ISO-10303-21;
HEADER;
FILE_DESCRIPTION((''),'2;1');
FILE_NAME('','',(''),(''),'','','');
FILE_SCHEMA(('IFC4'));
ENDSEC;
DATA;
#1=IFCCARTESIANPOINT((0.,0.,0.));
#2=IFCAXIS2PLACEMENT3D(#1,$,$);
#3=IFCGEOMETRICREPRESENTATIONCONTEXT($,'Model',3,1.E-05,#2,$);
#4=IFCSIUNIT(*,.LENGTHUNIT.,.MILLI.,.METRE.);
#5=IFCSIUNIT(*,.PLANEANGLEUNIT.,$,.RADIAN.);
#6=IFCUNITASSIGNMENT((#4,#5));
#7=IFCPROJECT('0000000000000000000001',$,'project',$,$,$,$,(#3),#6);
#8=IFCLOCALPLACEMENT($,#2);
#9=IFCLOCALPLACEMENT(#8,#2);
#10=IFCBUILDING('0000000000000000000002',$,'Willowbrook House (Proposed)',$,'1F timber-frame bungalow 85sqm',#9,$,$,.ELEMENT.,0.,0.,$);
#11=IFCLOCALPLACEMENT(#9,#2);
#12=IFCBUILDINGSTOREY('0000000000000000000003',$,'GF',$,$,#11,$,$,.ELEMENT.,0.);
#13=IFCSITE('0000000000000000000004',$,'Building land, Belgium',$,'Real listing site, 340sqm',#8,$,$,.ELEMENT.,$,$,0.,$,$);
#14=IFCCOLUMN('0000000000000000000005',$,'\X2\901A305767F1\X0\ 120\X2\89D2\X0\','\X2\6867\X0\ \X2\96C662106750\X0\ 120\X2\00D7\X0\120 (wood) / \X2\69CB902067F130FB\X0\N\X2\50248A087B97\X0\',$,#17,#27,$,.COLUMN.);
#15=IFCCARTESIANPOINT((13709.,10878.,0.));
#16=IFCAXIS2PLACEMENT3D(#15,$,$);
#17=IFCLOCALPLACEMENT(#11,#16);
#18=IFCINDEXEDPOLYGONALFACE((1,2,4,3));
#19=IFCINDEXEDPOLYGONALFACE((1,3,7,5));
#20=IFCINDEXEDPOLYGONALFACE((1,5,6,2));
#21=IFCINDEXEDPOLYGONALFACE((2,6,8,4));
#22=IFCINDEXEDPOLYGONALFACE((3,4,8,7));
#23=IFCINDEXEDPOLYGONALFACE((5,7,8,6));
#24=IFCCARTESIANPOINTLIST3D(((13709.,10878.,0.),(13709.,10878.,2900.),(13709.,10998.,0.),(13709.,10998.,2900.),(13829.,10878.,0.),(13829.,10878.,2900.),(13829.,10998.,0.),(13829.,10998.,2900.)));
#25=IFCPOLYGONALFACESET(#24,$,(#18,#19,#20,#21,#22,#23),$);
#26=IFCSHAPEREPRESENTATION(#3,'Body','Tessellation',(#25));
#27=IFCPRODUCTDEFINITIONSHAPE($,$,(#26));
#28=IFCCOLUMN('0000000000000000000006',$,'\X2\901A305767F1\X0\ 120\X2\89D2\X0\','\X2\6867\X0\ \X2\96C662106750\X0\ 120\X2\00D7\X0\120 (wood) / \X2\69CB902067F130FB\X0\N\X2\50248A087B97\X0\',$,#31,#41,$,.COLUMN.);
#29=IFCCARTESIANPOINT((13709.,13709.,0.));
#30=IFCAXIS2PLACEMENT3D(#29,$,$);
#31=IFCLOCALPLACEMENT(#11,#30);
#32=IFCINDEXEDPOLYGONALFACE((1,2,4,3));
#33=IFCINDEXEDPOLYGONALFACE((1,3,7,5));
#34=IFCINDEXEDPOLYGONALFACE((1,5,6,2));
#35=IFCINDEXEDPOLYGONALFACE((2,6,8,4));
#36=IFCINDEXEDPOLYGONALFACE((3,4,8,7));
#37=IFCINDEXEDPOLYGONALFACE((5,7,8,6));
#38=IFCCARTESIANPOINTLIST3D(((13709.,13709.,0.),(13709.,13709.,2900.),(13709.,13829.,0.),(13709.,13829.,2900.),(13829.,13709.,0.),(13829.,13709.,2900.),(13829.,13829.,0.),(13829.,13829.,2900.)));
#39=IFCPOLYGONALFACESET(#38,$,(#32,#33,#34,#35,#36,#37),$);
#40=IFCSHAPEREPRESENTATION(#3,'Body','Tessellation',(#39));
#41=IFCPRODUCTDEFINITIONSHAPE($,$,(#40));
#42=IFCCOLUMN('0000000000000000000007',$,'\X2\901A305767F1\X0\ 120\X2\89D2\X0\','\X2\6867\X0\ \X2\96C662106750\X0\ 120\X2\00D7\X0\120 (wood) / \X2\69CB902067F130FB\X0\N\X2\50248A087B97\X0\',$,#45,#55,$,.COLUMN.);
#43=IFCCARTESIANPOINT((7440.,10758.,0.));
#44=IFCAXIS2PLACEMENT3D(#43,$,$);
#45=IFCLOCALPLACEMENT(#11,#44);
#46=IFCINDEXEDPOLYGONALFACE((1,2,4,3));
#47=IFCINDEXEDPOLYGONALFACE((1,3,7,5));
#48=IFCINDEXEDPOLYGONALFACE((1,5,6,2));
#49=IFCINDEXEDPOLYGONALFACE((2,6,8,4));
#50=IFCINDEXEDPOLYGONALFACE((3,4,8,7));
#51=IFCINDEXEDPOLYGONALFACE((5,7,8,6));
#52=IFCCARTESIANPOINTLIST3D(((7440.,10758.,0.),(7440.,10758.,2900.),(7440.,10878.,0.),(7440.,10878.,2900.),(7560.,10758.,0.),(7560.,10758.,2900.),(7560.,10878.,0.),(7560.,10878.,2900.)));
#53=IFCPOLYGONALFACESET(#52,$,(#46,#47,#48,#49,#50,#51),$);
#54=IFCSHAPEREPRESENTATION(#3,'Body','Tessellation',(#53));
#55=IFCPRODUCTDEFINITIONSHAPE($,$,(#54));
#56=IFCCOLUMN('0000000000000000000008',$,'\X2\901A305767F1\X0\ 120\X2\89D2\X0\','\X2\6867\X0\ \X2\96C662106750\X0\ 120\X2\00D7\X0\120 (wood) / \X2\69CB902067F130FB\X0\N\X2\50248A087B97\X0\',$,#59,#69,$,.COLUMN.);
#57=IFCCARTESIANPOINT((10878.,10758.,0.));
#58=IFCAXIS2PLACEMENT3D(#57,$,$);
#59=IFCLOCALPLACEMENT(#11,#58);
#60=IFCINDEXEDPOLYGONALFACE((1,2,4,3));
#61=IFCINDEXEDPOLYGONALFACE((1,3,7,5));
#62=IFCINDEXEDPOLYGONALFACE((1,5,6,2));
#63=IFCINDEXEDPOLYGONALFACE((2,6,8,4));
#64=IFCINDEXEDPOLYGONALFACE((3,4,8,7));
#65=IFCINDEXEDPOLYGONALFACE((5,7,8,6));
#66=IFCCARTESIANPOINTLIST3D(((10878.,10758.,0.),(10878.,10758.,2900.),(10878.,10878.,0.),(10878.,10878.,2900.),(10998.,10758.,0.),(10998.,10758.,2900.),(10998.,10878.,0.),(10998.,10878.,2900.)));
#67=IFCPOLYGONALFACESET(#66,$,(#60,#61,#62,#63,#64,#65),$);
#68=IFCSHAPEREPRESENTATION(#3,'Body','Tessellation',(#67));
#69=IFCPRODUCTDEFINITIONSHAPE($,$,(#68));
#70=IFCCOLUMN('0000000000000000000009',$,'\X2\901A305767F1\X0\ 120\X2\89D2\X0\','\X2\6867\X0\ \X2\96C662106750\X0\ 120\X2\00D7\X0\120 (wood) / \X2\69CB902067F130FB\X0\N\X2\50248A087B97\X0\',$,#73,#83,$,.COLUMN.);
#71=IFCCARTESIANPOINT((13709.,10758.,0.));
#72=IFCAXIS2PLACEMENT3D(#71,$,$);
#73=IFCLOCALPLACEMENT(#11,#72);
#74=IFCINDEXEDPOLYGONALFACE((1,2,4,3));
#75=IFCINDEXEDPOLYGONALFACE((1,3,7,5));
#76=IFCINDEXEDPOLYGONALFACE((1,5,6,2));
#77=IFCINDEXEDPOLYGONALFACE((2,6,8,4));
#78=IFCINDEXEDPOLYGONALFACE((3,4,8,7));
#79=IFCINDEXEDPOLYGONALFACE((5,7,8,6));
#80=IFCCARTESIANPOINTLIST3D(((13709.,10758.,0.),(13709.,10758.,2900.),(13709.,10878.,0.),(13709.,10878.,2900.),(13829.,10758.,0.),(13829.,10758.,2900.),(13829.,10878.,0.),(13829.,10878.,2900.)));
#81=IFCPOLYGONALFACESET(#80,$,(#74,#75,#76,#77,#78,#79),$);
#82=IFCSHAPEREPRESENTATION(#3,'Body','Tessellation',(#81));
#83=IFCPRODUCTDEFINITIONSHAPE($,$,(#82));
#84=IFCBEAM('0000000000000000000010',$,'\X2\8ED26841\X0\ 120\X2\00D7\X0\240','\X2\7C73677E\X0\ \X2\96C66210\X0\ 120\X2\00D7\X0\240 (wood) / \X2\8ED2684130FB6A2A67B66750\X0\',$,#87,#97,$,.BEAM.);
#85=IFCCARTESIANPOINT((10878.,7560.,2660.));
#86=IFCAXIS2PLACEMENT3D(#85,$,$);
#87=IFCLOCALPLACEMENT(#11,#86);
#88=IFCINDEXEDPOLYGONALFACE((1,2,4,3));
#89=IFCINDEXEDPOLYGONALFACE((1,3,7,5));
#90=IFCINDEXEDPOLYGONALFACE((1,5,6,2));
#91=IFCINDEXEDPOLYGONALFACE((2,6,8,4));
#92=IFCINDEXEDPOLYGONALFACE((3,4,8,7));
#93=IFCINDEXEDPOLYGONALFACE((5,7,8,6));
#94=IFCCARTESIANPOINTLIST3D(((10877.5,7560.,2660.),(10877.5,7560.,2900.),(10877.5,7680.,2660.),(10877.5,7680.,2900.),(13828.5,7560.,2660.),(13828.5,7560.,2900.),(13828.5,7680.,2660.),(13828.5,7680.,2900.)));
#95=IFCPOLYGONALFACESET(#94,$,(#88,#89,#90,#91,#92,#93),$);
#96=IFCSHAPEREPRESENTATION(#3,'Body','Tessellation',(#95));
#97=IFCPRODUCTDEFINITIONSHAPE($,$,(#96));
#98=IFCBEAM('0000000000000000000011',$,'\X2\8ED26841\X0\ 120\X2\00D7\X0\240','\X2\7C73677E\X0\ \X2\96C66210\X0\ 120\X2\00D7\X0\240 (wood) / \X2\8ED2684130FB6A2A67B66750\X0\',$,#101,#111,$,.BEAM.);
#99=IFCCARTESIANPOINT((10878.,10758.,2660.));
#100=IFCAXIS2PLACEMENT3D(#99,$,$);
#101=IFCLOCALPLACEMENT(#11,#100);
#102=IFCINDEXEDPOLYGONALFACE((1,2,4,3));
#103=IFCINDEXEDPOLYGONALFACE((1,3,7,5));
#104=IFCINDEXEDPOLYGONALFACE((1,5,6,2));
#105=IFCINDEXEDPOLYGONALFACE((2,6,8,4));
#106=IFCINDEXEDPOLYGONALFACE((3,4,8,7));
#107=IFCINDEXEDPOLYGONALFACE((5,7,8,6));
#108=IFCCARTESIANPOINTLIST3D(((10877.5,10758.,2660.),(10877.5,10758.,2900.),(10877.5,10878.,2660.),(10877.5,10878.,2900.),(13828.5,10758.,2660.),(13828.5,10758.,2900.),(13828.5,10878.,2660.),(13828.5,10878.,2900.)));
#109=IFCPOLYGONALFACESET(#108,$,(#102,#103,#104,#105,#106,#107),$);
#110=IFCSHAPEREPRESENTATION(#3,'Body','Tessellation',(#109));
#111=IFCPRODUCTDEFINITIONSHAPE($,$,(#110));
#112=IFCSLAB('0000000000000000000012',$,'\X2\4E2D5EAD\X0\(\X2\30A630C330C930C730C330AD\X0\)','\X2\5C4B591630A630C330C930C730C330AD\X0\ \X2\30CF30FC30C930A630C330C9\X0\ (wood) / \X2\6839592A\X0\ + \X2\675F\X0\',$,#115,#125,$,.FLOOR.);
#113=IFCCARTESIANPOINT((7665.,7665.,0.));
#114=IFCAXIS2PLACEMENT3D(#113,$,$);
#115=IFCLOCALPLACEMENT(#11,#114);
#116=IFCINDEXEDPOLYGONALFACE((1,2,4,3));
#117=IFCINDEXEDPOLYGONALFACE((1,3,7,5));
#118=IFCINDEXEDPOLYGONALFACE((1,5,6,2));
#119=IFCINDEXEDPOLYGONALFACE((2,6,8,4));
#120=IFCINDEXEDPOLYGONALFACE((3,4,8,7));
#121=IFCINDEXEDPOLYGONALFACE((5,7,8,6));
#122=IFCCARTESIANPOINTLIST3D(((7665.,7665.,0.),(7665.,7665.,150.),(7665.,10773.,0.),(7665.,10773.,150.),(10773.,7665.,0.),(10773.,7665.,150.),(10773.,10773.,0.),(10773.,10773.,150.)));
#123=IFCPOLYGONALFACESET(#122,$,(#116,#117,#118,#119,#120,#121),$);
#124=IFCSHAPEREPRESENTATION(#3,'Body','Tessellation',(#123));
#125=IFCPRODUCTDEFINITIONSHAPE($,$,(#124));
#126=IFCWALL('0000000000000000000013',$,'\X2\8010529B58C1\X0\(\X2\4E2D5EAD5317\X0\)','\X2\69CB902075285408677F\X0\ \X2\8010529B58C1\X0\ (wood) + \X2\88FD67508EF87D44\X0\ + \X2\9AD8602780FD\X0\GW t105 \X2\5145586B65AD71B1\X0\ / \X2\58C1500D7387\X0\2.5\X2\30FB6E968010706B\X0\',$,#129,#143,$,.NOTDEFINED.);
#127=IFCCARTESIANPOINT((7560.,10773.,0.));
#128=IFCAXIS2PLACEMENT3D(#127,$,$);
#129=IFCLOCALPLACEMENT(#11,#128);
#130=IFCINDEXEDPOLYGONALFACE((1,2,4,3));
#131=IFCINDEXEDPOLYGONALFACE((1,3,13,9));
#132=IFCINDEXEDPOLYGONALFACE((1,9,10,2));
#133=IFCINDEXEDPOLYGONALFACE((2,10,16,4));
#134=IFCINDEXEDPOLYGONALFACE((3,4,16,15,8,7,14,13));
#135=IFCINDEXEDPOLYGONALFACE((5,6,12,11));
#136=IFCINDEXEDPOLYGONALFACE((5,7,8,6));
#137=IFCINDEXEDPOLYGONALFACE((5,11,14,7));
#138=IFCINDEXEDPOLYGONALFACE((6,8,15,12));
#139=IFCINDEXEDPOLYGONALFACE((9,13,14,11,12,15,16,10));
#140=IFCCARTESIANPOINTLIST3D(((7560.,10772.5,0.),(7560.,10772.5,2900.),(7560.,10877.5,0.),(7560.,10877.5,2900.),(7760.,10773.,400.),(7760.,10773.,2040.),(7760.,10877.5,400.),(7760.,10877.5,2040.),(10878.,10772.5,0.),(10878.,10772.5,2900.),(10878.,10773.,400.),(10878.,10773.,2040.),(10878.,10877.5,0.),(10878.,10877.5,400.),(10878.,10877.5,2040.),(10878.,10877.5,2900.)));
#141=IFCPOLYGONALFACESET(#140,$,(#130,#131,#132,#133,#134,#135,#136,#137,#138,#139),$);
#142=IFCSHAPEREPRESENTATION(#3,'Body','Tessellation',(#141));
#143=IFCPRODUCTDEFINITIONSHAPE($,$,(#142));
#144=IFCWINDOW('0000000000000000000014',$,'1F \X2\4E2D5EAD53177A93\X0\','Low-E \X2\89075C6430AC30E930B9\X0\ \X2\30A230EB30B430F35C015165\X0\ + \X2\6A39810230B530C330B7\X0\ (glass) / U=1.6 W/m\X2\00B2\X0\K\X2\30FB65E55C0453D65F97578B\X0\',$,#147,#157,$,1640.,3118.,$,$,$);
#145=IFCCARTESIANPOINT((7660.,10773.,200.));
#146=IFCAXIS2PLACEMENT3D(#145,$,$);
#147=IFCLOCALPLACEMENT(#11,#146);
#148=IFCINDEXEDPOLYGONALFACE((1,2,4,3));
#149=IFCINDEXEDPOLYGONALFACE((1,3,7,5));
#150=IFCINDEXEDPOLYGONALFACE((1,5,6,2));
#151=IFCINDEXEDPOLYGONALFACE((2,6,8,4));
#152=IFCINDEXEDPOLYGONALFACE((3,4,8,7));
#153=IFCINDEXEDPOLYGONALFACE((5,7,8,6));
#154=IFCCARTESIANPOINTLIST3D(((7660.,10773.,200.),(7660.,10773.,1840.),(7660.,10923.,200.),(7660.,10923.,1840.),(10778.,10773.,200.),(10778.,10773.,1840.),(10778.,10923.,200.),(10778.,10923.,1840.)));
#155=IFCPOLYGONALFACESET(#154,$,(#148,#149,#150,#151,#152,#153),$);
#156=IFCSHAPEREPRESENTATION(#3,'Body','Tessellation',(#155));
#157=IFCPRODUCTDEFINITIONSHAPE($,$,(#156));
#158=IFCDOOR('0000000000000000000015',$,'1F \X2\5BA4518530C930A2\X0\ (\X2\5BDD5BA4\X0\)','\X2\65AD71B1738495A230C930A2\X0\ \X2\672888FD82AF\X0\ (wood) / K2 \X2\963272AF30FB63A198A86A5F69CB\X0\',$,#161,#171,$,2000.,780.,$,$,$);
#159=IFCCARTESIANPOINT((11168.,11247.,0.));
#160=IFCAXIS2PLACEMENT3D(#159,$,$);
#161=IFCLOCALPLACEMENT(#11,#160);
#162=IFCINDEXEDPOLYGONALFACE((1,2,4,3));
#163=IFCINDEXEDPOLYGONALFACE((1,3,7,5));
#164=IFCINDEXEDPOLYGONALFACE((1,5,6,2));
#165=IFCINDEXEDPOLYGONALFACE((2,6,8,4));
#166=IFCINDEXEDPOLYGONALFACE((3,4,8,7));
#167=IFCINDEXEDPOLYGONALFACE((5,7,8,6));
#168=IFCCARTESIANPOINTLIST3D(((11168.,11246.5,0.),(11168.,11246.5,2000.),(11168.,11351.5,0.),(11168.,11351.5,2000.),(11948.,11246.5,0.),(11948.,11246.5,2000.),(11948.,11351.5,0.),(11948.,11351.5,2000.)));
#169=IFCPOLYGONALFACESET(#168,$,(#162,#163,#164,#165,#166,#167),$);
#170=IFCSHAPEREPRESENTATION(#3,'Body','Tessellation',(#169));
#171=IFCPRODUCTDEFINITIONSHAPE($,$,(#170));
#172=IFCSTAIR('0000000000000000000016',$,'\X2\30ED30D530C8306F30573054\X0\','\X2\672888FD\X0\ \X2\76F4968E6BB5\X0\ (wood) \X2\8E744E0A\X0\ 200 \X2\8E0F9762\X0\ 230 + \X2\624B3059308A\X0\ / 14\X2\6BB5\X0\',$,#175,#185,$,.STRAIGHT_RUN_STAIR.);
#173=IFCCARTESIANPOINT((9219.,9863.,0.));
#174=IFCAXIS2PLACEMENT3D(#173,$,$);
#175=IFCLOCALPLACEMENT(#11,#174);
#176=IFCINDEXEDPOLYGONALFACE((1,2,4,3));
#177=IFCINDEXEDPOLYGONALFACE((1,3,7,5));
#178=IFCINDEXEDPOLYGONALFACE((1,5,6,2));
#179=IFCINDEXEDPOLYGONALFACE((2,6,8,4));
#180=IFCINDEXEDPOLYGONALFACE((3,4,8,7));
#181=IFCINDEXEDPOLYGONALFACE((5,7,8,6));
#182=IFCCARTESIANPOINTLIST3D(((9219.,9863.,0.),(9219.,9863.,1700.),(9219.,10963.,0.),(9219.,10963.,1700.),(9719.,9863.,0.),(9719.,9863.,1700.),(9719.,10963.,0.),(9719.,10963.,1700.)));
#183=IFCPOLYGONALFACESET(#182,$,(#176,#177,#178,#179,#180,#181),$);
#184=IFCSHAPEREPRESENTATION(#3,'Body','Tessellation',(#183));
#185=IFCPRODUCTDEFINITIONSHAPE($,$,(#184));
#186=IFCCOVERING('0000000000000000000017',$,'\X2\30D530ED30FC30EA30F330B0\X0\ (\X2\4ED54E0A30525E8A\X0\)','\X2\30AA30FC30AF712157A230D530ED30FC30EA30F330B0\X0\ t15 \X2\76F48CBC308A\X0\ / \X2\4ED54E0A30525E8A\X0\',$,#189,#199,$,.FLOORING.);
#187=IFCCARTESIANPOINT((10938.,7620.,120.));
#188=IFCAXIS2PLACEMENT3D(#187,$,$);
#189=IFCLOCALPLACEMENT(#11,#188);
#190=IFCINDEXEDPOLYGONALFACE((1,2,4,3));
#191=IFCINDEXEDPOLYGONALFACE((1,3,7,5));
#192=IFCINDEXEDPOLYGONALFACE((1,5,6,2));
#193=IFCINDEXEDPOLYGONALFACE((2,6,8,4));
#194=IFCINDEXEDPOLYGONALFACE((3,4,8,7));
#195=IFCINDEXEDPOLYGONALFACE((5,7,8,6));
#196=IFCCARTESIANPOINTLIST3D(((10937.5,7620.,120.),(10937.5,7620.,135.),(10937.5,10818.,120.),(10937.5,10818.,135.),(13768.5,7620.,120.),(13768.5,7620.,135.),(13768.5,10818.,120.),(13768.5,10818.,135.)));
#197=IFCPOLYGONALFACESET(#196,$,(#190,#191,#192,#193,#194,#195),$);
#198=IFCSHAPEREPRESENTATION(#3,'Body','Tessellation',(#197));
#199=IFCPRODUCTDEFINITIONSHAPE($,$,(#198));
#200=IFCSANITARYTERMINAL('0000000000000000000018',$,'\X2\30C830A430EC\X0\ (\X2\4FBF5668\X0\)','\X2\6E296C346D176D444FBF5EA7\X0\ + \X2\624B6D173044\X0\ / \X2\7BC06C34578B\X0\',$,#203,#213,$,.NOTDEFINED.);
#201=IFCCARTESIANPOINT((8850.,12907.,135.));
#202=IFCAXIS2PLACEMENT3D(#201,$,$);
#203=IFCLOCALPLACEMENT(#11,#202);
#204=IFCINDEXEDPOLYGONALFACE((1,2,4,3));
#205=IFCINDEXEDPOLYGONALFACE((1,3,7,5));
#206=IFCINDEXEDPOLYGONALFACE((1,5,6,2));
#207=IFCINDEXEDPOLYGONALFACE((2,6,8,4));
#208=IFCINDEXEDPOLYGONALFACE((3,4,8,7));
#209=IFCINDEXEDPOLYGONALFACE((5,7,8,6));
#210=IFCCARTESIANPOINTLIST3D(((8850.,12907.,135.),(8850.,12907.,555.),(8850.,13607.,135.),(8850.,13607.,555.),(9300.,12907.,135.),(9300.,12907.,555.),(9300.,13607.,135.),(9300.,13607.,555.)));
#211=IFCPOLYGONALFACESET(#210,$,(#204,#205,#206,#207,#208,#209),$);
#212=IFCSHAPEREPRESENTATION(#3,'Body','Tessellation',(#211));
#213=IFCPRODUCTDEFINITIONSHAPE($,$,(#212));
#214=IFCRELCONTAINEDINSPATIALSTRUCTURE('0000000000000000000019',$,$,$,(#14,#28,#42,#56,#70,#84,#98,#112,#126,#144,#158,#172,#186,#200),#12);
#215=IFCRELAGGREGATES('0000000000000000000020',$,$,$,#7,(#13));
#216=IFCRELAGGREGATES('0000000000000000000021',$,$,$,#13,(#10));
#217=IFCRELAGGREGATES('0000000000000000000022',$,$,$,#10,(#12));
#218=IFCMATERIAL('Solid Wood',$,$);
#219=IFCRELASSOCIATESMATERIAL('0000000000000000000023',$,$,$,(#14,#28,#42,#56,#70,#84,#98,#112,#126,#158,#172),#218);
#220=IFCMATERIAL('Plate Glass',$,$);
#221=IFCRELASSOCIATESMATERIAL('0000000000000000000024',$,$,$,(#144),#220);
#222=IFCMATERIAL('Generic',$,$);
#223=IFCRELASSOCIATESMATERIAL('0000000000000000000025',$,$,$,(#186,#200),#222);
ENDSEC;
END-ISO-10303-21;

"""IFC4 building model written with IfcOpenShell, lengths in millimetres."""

from ifc_helpers import new_model, si_unit, frame, frame_2d, origin, place, context, project, spatial, rectangle, extrude, material, element, fill, save


model = new_model("IFC4")

# Units and contexts
model_context = context("Model", 3, precision=1e-05, world=origin())
ifc_project = project(units=[si_unit("LENGTHUNIT", "METRE", prefix="MILLI"), si_unit("PLANEANGLEUNIT", "RADIAN")], contexts=[model_context])

# Site, building, storey
site_placement = place(None, origin())
site = spatial("IfcSite", under=ifc_project, at=site_placement, Name="Building land, Belgium", ObjectType="Real listing site, 340sqm", CompositionType="ELEMENT", RefElevation=0.0)
building_placement = place(site_placement, origin())
building = spatial("IfcBuilding", under=site, at=building_placement, Name="Willowbrook House (Proposed)", ObjectType="1F timber-frame bungalow 85sqm", CompositionType="ELEMENT", ElevationOfRefHeight=0.0, ElevationOfTerrain=0.0)
storey_placement = place(building_placement, origin())
storey = spatial("IfcBuildingStorey", under=building, at=storey_placement, Name="GF", CompositionType="ELEMENT", Elevation=0.0)

# Columns
ifc_material_1 = material(Name="Solid Wood")
column_1_placement = place(storey_placement, frame((13709.0, 10878.0, 0.0)))
element("IfcColumn", 1, at=column_1_placement, inside=storey, material=ifc_material_1, Name="通し柱 120角", Description="桧 集成材 120×120 (wood) / 構造柱・N値計算", PredefinedType="COLUMN", context=model_context, shape_type="SweptSolid", body=[
    extrude(rectangle(XDim=120.0, YDim=120.0, at=frame_2d((60.0, 60.0))), frame((13709.0, 10878.0, 0.0)), (0.0, 0.0, 1.0), 2900.0),
])
column_2_placement = place(storey_placement, frame((13709.0, 13709.0, 0.0)))
element("IfcColumn", 2, at=column_2_placement, inside=storey, material=ifc_material_1, Name="通し柱 120角", Description="桧 集成材 120×120 (wood) / 構造柱・N値計算", PredefinedType="COLUMN", context=model_context, shape_type="SweptSolid", body=[
    extrude(rectangle(XDim=120.0, YDim=120.0, at=frame_2d((60.0, 60.0))), frame((13709.0, 13709.0, 0.0)), (0.0, 0.0, 1.0), 2900.0),
])
column_3_placement = place(storey_placement, frame((7440.0, 10758.0, 0.0)))
element("IfcColumn", 3, at=column_3_placement, inside=storey, material=ifc_material_1, Name="通し柱 120角", Description="桧 集成材 120×120 (wood) / 構造柱・N値計算", PredefinedType="COLUMN", context=model_context, shape_type="SweptSolid", body=[
    extrude(rectangle(XDim=120.0, YDim=120.0, at=frame_2d((60.0, 60.0))), frame((7440.0, 10758.0, 0.0)), (0.0, 0.0, 1.0), 2900.0),
])
column_4_placement = place(storey_placement, frame((10878.0, 10758.0, 0.0)))
element("IfcColumn", 4, at=column_4_placement, inside=storey, material=ifc_material_1, Name="通し柱 120角", Description="桧 集成材 120×120 (wood) / 構造柱・N値計算", PredefinedType="COLUMN", context=model_context, shape_type="SweptSolid", body=[
    extrude(rectangle(XDim=120.0, YDim=120.0, at=frame_2d((60.0, 60.0))), frame((10878.0, 10758.0, 0.0)), (0.0, 0.0, 1.0), 2900.0),
])
column_5_placement = place(storey_placement, frame((13709.0, 10758.0, 0.0)))
element("IfcColumn", 5, at=column_5_placement, inside=storey, material=ifc_material_1, Name="通し柱 120角", Description="桧 集成材 120×120 (wood) / 構造柱・N値計算", PredefinedType="COLUMN", context=model_context, shape_type="SweptSolid", body=[
    extrude(rectangle(XDim=120.0, YDim=120.0, at=frame_2d((60.0, 60.0))), frame((13709.0, 10758.0, 0.0)), (0.0, 0.0, 1.0), 2900.0),
])

# Beams
beam_1_placement = place(storey_placement, frame((10878.0, 7560.0, 2660.0)))
element("IfcBeam", 6, at=beam_1_placement, inside=storey, material=ifc_material_1, Name="軒桁 120×240", Description="米松 集成 120×240 (wood) / 軒桁・横架材", PredefinedType="BEAM", context=model_context, shape_type="SweptSolid", body=[
    extrude(rectangle(XDim=2951.0, YDim=120.0, at=frame_2d((1475.0, 60.0))), frame((10878.0, 7560.0, 2660.0)), (0.0, 0.0, 1.0), 240.0),
])
beam_2_placement = place(storey_placement, frame((10878.0, 10758.0, 2660.0)))
element("IfcBeam", 7, at=beam_2_placement, inside=storey, material=ifc_material_1, Name="軒桁 120×240", Description="米松 集成 120×240 (wood) / 軒桁・横架材", PredefinedType="BEAM", context=model_context, shape_type="SweptSolid", body=[
    extrude(rectangle(XDim=2951.0, YDim=120.0, at=frame_2d((1475.0, 60.0))), frame((10878.0, 10758.0, 2660.0)), (0.0, 0.0, 1.0), 240.0),
])

# Slab
slab_placement = place(storey_placement, frame((7665.0, 7665.0, 0.0)))
element("IfcSlab", 8, at=slab_placement, inside=storey, material=ifc_material_1, Name="中庭(ウッドデッキ)", Description="屋外ウッドデッキ ハードウッド (wood) / 根太 + 束", PredefinedType="FLOOR", context=model_context, shape_type="SweptSolid", body=[
    extrude(rectangle(XDim=3108.0, YDim=3108.0, at=frame_2d((1554.0, 1554.0))), frame((7665.0, 7665.0, 0.0)), (0.0, 0.0, 1.0), 150.0),
])

# Wall, opening, window
wall_1_placement = place(storey_placement, frame((7560.0, 10773.0, 0.0)))
wall_1 = element("IfcWall", 9, at=wall_1_placement, inside=storey, material=ifc_material_1, Name="耐力壁(中庭北)", Description="構造用合板 耐力壁 (wood) + 製材軸組 + 高性能GW t105 充填断熱 / 壁倍率2.5・準耐火", PredefinedType="NOTDEFINED", context=model_context, shape_type="SweptSolid", body=[
    extrude(rectangle(XDim=3318.0, YDim=105.0, at=frame_2d((1659.0, 52.0))), frame((7560.0, 10773.0, 0.0)), (0.0, 0.0, 1.0), 2900.0),
])
opening_placement = place(storey_placement, frame((7660.0, 10773.0, 200.0)))
opening = element("IfcOpeningElement", 10, at=opening_placement, cuts=wall_1, PredefinedType="NOTDEFINED", context=model_context, shape_type="SweptSolid", body=[
    extrude(rectangle(XDim=3118.0, YDim=150.0, at=frame_2d((1559.0, 75.0))), frame((7660.0, 10773.0, 200.0)), (0.0, 0.0, 1.0), 1640.0),
])
ifc_material_2 = material(Name="Plate Glass")
window_placement = place(storey_placement, frame((7660.0, 10773.0, 200.0)))
window = element("IfcWindow", 11, at=window_placement, inside=storey, material=ifc_material_2, Name="1F 中庭北窓", Description="Low-E 複層ガラス アルゴン封入 + 樹脂サッシ (glass) / U=1.6 W/m²K・日射取得型", OverallHeight=1640.0, OverallWidth=3118.0, context=model_context, shape_type="SweptSolid", body=[
    extrude(rectangle(XDim=3118.0, YDim=150.0, at=frame_2d((1559.0, 75.0))), frame((7660.0, 10773.0, 200.0)), (0.0, 0.0, 1.0), 1640.0),
])
fill(opening, window)

# Door
door_placement = place(storey_placement, frame((11168.0, 11247.0, 0.0)))
element("IfcDoor", 12, at=door_placement, inside=storey, material=ifc_material_1, Name="1F 室内ドア (寝室)", Description="断熱玄関ドア 木製芯 (wood) / K2 防犯・採風機構", OverallHeight=2000.0, OverallWidth=780.0, context=model_context, shape_type="SweptSolid", body=[
    extrude(rectangle(XDim=780.0, YDim=105.0, at=frame_2d((390.0, 52.0))), frame((11168.0, 11247.0, 0.0)), (0.0, 0.0, 1.0), 2000.0),
])

# Stair
stair_placement = place(storey_placement, frame((9219.0, 9863.0, 0.0)))
element("IfcStair", 13, at=stair_placement, inside=storey, material=ifc_material_1, Name="ロフトはしご", Description="木製 直階段 (wood) 蹴上 200 踏面 230 + 手すり / 14段", PredefinedType="STRAIGHT_RUN_STAIR", context=model_context, shape_type="SweptSolid", body=[
    extrude(rectangle(XDim=500.0, YDim=1100.0, at=frame_2d((250.0, 550.0))), frame((9219.0, 9863.0, 0.0)), (0.0, 0.0, 1.0), 1700.0),
])

# Covering
ifc_material_3 = material(Name="Generic")
covering_placement = place(storey_placement, frame((10938.0, 7620.0, 120.0)))
element("IfcCovering", 14, at=covering_placement, inside=storey, material=ifc_material_3, Name="フローリング (仕上げ床)", Description="オーク無垢フローリング t15 直貼り / 仕上げ床", PredefinedType="FLOORING", context=model_context, shape_type="SweptSolid", body=[
    extrude(rectangle(XDim=2831.0, YDim=3198.0, at=frame_2d((1415.0, 1599.0))), frame((10938.0, 7620.0, 120.0)), (0.0, 0.0, 1.0), 15.0),
])

# Sanitary terminal
sanitary_terminal_placement = place(storey_placement, frame((8850.0, 12907.0, 135.0)))
element("IfcSanitaryTerminal", 15, at=sanitary_terminal_placement, inside=storey, material=ifc_material_3, Name="トイレ (便器)", Description="温水洗浄便座 + 手洗い / 節水型", PredefinedType="NOTDEFINED", context=model_context, shape_type="SweptSolid", body=[
    extrude(rectangle(XDim=450.0, YDim=700.0, at=frame_2d((225.0, 350.0))), frame((8850.0, 12907.0, 135.0)), (0.0, 0.0, 1.0), 420.0),
])

save(model, "model.ifc")
